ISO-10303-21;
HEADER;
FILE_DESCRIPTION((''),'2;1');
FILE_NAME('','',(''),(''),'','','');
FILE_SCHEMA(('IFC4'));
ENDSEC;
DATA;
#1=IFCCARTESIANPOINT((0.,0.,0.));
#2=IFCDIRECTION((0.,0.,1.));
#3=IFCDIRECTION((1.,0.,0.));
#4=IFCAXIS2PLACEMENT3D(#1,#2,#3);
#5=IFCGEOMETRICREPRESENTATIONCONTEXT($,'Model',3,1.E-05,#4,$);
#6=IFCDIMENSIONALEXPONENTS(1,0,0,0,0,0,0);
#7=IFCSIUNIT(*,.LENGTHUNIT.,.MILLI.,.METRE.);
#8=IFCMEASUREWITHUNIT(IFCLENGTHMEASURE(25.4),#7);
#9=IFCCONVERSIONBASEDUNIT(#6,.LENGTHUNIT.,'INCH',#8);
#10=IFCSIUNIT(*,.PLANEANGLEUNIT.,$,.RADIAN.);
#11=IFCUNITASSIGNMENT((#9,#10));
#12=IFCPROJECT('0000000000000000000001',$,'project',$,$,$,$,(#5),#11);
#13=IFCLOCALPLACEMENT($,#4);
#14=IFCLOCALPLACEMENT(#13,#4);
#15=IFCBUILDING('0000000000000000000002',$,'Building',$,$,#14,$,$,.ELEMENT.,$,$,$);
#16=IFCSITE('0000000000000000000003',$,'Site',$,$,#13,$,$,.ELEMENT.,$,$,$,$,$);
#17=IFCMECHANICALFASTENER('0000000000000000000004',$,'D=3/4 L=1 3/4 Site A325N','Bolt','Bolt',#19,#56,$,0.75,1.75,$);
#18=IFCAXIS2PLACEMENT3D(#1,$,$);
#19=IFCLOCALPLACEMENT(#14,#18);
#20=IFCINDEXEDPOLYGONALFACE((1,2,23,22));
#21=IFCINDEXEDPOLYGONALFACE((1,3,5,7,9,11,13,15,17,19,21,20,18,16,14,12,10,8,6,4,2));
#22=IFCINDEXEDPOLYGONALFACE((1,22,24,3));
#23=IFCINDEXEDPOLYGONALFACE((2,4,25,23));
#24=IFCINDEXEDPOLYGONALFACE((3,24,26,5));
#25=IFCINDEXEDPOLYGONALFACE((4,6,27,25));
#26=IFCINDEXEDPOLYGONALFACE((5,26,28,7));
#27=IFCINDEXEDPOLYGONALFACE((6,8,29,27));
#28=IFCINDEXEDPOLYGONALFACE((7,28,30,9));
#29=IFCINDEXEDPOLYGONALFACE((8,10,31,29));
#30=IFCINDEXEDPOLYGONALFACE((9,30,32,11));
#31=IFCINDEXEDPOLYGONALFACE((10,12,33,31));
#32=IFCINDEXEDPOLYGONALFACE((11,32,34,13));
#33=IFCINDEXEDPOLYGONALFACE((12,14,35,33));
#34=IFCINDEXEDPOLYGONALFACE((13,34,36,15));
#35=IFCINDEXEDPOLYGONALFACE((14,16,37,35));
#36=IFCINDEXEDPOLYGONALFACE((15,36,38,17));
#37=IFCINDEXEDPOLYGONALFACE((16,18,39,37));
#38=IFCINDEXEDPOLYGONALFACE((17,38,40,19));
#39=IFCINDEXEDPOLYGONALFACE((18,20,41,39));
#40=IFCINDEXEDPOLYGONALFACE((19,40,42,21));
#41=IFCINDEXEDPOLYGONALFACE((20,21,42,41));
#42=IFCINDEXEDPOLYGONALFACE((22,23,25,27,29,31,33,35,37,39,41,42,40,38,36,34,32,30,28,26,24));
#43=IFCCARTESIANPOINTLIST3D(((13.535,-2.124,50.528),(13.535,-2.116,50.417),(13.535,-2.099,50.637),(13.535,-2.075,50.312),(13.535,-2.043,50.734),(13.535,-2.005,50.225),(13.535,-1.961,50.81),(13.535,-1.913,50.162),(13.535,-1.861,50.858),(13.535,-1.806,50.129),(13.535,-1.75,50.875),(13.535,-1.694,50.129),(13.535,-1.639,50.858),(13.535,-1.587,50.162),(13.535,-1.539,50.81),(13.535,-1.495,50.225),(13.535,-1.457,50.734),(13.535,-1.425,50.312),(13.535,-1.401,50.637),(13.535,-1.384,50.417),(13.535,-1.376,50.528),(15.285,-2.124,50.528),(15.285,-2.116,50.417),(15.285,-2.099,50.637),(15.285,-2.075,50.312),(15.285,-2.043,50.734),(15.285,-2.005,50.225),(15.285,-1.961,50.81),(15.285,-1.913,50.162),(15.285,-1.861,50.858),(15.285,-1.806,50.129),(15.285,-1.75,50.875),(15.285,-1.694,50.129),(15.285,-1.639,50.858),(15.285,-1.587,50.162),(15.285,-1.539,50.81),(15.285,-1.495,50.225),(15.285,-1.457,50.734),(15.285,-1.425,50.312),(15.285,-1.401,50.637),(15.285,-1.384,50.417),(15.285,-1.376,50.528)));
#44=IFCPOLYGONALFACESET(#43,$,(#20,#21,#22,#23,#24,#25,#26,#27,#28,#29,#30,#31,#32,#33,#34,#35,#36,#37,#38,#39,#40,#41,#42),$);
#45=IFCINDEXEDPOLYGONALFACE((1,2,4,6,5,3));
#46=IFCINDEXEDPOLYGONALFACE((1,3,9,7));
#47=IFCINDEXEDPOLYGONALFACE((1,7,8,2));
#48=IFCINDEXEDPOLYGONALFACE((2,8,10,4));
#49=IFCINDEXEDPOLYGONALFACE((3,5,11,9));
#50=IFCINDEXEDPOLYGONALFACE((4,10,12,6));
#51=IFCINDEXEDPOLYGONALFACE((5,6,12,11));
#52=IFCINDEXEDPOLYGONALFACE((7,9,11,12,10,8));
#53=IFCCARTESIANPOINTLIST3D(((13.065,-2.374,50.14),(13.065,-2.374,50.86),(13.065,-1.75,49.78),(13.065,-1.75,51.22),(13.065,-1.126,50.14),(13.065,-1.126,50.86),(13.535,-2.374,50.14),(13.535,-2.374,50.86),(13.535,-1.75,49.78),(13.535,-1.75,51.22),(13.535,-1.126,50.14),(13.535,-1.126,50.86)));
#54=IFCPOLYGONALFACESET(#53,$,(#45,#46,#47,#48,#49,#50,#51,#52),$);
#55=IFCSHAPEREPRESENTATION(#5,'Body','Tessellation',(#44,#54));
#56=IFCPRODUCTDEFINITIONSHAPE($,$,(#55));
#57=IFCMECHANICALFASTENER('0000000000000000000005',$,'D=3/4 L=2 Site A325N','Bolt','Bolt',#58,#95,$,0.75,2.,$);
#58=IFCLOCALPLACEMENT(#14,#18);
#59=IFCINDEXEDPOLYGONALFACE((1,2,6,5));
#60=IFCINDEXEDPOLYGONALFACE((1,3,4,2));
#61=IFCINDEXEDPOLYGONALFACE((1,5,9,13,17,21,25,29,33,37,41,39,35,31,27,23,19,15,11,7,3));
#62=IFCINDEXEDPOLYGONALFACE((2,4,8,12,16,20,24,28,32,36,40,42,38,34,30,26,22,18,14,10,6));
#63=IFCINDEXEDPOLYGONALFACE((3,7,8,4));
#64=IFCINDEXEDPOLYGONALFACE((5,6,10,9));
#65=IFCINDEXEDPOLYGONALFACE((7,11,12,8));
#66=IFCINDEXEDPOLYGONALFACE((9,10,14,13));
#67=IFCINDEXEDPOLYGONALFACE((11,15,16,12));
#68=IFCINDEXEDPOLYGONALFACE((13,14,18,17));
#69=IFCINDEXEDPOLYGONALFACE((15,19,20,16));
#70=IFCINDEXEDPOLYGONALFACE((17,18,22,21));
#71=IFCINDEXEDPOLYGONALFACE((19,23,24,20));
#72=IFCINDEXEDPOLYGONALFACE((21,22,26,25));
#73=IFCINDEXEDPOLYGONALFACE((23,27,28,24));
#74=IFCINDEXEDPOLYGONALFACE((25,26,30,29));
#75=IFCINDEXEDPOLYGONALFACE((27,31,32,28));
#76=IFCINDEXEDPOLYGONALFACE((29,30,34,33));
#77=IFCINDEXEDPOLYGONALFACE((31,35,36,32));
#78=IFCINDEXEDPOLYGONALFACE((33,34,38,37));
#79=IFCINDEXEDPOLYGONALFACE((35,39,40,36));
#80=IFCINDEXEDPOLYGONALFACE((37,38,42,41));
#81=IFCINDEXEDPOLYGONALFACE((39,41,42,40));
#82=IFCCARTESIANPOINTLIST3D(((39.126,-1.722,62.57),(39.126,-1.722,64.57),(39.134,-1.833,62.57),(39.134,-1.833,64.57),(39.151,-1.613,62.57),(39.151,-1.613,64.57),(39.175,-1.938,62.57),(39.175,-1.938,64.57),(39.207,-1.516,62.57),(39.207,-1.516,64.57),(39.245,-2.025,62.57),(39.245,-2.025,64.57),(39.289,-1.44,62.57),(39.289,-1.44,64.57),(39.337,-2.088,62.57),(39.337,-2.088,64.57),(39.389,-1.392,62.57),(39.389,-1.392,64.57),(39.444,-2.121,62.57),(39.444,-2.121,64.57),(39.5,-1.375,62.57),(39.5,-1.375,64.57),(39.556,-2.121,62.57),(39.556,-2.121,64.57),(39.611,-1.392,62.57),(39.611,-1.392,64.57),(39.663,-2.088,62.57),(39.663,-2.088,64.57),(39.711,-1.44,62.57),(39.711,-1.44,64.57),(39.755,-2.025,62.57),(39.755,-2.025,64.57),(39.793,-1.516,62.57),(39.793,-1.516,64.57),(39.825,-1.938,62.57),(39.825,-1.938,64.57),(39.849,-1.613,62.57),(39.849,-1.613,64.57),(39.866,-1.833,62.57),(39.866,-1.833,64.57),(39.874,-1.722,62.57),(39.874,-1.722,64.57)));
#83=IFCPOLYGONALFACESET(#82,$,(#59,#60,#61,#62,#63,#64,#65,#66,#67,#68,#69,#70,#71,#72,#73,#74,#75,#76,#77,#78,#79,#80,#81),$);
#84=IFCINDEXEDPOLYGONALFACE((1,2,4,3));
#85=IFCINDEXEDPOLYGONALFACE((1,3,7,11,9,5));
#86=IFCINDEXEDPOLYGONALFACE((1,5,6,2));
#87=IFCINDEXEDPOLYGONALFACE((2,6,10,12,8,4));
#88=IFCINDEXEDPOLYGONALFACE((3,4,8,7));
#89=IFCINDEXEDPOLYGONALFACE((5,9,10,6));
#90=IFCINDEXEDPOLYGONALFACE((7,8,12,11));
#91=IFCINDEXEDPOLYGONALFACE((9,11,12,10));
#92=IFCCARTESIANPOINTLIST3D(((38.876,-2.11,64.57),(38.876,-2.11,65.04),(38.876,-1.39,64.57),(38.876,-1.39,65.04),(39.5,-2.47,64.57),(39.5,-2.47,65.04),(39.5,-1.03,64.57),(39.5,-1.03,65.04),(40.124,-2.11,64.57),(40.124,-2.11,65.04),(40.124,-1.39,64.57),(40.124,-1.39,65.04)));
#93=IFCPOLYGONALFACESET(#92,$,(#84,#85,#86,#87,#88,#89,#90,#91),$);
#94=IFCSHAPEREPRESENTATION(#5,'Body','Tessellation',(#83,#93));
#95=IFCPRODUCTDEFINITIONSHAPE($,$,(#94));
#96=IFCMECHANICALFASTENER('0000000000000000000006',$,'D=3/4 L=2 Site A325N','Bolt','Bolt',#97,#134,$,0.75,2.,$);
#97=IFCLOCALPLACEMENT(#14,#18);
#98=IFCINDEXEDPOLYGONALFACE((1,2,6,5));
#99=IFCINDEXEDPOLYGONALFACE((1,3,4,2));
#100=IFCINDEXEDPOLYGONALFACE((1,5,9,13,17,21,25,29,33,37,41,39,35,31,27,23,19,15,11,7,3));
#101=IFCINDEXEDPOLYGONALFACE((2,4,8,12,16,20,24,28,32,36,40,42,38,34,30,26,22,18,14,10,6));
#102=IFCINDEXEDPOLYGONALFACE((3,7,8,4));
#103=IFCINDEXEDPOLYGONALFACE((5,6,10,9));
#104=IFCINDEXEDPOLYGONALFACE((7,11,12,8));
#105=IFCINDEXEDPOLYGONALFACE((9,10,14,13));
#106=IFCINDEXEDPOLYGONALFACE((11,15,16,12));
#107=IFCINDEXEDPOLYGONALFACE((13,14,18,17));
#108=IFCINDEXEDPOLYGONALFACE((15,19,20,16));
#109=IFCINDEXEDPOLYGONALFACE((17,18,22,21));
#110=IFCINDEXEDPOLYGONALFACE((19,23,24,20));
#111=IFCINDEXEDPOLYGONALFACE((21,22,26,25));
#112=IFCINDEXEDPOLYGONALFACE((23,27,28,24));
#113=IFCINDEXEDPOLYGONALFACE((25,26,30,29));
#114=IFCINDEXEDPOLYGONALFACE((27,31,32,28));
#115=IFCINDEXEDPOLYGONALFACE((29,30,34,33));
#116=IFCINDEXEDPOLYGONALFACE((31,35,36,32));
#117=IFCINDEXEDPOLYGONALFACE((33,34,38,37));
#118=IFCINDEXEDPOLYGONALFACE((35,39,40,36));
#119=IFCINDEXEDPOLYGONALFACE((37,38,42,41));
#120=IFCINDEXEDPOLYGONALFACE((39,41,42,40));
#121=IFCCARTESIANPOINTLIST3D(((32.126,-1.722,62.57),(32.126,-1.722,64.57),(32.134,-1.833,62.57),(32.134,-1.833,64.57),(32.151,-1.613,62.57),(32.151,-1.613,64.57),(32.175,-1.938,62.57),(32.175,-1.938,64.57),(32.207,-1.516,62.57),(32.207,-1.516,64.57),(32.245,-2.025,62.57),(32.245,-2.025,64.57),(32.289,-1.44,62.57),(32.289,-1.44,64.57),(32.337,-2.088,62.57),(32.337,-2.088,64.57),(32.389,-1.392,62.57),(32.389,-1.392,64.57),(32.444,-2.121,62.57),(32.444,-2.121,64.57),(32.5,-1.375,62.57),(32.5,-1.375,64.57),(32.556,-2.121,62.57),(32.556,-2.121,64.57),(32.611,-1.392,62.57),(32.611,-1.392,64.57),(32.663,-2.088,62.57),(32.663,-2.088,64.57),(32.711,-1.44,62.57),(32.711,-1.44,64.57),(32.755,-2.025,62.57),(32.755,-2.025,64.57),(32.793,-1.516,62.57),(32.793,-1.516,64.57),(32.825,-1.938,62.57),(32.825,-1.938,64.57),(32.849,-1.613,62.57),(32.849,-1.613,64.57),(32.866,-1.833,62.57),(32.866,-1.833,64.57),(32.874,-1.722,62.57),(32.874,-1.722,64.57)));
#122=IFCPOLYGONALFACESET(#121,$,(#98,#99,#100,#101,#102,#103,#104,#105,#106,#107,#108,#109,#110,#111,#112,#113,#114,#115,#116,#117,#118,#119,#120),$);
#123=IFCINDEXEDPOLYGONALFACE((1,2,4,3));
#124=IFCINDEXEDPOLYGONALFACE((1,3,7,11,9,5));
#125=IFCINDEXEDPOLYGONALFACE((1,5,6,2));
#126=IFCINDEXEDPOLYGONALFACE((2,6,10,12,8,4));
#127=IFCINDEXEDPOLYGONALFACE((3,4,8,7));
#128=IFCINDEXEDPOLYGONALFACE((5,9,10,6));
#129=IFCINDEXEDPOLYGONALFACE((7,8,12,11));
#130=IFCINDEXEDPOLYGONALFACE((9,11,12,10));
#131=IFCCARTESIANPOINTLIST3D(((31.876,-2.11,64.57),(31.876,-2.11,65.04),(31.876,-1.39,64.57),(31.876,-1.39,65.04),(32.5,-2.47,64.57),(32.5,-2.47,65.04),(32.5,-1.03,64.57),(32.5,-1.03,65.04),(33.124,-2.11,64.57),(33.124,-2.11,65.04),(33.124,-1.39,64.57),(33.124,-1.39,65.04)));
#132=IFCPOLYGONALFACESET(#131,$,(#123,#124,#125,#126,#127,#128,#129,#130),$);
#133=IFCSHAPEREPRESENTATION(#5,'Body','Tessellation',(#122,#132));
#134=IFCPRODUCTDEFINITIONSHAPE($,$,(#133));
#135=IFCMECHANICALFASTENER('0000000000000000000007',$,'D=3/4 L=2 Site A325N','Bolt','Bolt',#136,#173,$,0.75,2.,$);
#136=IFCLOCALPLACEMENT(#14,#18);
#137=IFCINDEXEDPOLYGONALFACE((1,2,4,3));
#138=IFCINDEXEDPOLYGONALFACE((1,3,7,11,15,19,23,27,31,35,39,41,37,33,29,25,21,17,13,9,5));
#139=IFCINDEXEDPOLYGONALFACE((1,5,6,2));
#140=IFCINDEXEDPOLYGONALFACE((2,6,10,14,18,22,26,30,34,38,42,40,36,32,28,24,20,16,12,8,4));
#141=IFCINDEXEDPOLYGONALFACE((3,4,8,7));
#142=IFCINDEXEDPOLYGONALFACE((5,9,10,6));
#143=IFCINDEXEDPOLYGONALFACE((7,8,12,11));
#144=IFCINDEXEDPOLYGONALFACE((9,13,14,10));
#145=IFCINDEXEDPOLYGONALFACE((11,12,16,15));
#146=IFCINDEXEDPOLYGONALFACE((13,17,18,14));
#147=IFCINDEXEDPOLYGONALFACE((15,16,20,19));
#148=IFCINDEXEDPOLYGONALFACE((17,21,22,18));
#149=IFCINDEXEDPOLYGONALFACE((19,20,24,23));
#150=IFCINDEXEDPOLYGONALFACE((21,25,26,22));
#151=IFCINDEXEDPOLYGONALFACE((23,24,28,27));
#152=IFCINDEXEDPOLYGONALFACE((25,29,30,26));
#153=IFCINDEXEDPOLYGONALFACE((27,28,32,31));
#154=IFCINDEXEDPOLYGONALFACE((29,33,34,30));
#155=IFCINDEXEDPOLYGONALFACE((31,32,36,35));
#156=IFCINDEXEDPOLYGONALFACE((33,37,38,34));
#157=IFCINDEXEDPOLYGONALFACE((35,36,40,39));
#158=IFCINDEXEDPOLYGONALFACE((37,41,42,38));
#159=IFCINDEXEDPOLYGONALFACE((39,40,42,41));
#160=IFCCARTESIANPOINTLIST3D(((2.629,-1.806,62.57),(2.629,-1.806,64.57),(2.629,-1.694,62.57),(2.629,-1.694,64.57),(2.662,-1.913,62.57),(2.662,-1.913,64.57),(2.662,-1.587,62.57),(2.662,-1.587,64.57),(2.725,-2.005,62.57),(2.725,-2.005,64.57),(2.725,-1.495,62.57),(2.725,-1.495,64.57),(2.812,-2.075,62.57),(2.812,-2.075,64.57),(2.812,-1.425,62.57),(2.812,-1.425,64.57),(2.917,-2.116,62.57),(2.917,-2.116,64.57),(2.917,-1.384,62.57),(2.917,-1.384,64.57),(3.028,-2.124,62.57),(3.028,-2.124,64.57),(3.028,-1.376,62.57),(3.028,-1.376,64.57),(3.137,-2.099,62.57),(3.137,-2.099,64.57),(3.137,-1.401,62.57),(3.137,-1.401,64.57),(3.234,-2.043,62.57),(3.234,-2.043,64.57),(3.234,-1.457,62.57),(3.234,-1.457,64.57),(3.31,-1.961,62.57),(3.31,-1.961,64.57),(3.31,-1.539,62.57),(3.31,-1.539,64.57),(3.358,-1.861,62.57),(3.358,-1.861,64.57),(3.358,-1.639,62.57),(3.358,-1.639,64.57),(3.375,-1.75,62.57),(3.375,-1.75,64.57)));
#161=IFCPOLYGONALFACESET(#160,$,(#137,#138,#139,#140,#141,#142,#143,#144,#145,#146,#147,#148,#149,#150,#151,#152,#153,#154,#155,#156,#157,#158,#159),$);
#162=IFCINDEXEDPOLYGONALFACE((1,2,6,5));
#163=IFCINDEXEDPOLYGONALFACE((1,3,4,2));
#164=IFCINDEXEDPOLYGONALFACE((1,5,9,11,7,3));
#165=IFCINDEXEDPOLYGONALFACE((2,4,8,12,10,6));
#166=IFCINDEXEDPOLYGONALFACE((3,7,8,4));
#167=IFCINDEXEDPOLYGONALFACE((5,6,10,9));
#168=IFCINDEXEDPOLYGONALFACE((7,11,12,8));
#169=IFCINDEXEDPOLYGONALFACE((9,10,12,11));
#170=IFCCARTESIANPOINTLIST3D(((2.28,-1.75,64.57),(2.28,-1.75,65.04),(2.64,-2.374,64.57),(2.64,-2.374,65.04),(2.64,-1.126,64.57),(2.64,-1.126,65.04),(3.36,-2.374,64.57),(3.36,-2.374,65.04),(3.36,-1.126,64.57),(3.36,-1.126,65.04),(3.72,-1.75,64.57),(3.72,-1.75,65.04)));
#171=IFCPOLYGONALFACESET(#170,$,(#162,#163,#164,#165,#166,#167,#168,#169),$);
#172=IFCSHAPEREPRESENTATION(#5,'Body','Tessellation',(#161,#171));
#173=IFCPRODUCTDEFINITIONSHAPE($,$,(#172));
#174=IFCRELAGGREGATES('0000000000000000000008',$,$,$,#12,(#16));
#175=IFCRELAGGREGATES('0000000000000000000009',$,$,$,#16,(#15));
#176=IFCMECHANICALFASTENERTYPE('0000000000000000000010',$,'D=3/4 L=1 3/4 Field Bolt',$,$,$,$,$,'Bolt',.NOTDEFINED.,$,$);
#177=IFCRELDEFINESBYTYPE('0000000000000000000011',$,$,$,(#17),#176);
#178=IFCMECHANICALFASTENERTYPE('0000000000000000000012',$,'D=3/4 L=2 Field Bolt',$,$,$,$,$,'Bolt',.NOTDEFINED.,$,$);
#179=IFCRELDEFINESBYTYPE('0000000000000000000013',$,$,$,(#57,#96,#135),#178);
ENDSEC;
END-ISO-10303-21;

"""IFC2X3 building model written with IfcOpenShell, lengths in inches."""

from ifc_helpers import new_model, entity, si_unit, converted_unit, frame, origin_with_axes, origin_2d_with_axis, place, context, project, spatial, polyline, circle, outline, extrude, source, transform, mapped, type_object, type_shapes, element, save


model = new_model("IFC2X3")

# Units and contexts
model_context = context("Model", 3, precision=1e-05, world=origin_with_axes())
ifc_project = project(units=[converted_unit("LENGTHUNIT", "INCH", entity("IfcLengthMeasure", 25.4), si_unit("LENGTHUNIT", "METRE", prefix="MILLI"), dimensions=[1, 0, 0, 0, 0, 0, 0]), si_unit("PLANEANGLEUNIT", "RADIAN")], contexts=[model_context])

# Site, building
site_placement = place(None, origin_with_axes())
site = spatial("IfcSite", under=ifc_project, at=site_placement, Name="Site", CompositionType="ELEMENT")
building_placement = place(site_placement, origin_with_axes())
building = spatial("IfcBuilding", under=site, at=building_placement, Name="Building", CompositionType="ELEMENT")

# Shared definitions
assembly_1_placement = place(building_placement, frame((36.0, 0.0, 46.0), z_axis=(-1.0, 0.0, 0.0), x_axis=(0.0, 0.0, 1.0)))

# Shared definitions
assembly_2_placement = place(building_placement, frame((36.0, 0.0, 58.0), z_axis=(0.0, 0.0, 1.0), x_axis=(-1.0, 0.0, 0.0)))

# Shared definitions
assembly_3_placement = place(building_placement, frame((0.0, 0.0, 80.0), z_axis=(0.0, 0.0, 1.0), x_axis=(1.0, 0.0, 0.0)))

# Mechanical fasteners
mechanical_fastener_type_1 = type_object("IfcMechanicalFastenerType", Name="D=3/4 L=1 3/4 Field Bolt", ElementType="Bolt")
shared_shape_1 = source(origin_with_axes(), model_context, "Body", "SweptSolid", [
    extrude(circle(Radius=0.375, at=origin_2d_with_axis()), frame((0.0, 0.0, 0.0), z_axis=(1.0, 0.0, 0.0), x_axis=(0.0, 1.0, 0.0)), (0.0, 0.0, 1.0), 1.75),
    extrude(outline(polyline([(-0.72, 0.0), (-0.36, 0.624), (0.36, 0.624), (0.72, 0.0), (0.36, -0.624), (-0.36, -0.624), (-0.72, 0.0)])), frame((0.0, 0.0, 0.0), z_axis=(1.0, 0.0, 0.0), x_axis=(0.0, 1.0, 0.0)), (0.0, 0.0, -1.0), 0.47),
])
type_shapes(mechanical_fastener_type_1, [shared_shape_1])
placement_1 = place(assembly_2_placement, frame((22.465, 1.75, 1.5), z_axis=(0.0, 1.0, 0.0), x_axis=(-1.0, 0.0, 0.0)))
for number, where, z_axis, x_axis, name in (
    (1, (0.0, -9.0, 0.0), (0.0, 0.0, 1.0), (1.0, 0.0, 0.0), "D=3/4 L=1 3/4 Site A325N"),
):
    element("IfcMechanicalFastener", number, at=place(placement_1, frame(where, z_axis=z_axis, x_axis=x_axis)), type_object=mechanical_fastener_type_1, Name=name, Description="Bolt", ObjectType="Bolt", NominalDiameter=0.75, NominalLength=1.75, context=model_context, shape_type="MappedRepresentation", body=[
        mapped(shared_shape_1, transform((0.0, 0.0, 0.0), scale=1.0)),
    ])
mechanical_fastener_type_2 = type_object("IfcMechanicalFastenerType", Name="D=3/4 L=2 Field Bolt", ElementType="Bolt")
shared_shape_2 = source(origin_with_axes(), model_context, "Body", "SweptSolid", [
    extrude(circle(Radius=0.375, at=origin_2d_with_axis()), frame((0.0, 0.0, 0.0), z_axis=(1.0, 0.0, 0.0), x_axis=(0.0, 1.0, 0.0)), (0.0, 0.0, 1.0), 2.0),
    extrude(outline(polyline([(-0.72, 0.0), (-0.36, 0.624), (0.36, 0.624), (0.72, 0.0), (0.36, -0.624), (-0.36, -0.624), (-0.72, 0.0)])), frame((0.0, 0.0, 0.0), z_axis=(1.0, 0.0, 0.0), x_axis=(0.0, 1.0, 0.0)), (0.0, 0.0, -1.0), 0.47),
])
type_shapes(mechanical_fastener_type_2, [shared_shape_2])
placement_2 = place(assembly_1_placement, frame((18.57, -1.75, 3.5), z_axis=(0.0, 0.0, -1.0), x_axis=(-1.0, 0.0, 0.0)))
for number, where, z_axis, x_axis, name in (
    (2, (0.0, 0.0, 7.0), (0.0, 0.0, 1.0), (1.0, 0.0, 0.0), "D=3/4 L=2 Site A325N"),
    (3, (0.0, 0.0, 0.0), (0.0, 0.0, 1.0), (1.0, 0.0, 0.0), "D=3/4 L=2 Site A325N"),
):
    element("IfcMechanicalFastener", number, at=place(placement_2, frame(where, z_axis=z_axis, x_axis=x_axis)), type_object=mechanical_fastener_type_2, Name=name, Description="Bolt", ObjectType="Bolt", NominalDiameter=0.75, NominalLength=2.0, context=model_context, shape_type="MappedRepresentation", body=[
        mapped(shared_shape_2, transform((0.0, 0.0, 0.0), scale=1.0)),
    ])
placement_3 = place(assembly_3_placement, frame((3.0, 1.75, -15.43), z_axis=(0.0, -1.0, 0.0), x_axis=(0.0, 0.0, -1.0)))
mechanical_fastener_1_placement = place(placement_3, frame((0.0, 0.0, 3.5), z_axis=(0.0, 0.0, 1.0), x_axis=(1.0, 0.0, 0.0)))
element("IfcMechanicalFastener", 4, at=mechanical_fastener_1_placement, type_object=mechanical_fastener_type_2, Name="D=3/4 L=2 Site A325N", Description="Bolt", ObjectType="Bolt", NominalDiameter=0.75, NominalLength=2.0, context=model_context, shape_type="MappedRepresentation", body=[
    mapped(shared_shape_2, transform((0.0, 0.0, 0.0), scale=1.0)),
])

save(model, "model.ifc")
